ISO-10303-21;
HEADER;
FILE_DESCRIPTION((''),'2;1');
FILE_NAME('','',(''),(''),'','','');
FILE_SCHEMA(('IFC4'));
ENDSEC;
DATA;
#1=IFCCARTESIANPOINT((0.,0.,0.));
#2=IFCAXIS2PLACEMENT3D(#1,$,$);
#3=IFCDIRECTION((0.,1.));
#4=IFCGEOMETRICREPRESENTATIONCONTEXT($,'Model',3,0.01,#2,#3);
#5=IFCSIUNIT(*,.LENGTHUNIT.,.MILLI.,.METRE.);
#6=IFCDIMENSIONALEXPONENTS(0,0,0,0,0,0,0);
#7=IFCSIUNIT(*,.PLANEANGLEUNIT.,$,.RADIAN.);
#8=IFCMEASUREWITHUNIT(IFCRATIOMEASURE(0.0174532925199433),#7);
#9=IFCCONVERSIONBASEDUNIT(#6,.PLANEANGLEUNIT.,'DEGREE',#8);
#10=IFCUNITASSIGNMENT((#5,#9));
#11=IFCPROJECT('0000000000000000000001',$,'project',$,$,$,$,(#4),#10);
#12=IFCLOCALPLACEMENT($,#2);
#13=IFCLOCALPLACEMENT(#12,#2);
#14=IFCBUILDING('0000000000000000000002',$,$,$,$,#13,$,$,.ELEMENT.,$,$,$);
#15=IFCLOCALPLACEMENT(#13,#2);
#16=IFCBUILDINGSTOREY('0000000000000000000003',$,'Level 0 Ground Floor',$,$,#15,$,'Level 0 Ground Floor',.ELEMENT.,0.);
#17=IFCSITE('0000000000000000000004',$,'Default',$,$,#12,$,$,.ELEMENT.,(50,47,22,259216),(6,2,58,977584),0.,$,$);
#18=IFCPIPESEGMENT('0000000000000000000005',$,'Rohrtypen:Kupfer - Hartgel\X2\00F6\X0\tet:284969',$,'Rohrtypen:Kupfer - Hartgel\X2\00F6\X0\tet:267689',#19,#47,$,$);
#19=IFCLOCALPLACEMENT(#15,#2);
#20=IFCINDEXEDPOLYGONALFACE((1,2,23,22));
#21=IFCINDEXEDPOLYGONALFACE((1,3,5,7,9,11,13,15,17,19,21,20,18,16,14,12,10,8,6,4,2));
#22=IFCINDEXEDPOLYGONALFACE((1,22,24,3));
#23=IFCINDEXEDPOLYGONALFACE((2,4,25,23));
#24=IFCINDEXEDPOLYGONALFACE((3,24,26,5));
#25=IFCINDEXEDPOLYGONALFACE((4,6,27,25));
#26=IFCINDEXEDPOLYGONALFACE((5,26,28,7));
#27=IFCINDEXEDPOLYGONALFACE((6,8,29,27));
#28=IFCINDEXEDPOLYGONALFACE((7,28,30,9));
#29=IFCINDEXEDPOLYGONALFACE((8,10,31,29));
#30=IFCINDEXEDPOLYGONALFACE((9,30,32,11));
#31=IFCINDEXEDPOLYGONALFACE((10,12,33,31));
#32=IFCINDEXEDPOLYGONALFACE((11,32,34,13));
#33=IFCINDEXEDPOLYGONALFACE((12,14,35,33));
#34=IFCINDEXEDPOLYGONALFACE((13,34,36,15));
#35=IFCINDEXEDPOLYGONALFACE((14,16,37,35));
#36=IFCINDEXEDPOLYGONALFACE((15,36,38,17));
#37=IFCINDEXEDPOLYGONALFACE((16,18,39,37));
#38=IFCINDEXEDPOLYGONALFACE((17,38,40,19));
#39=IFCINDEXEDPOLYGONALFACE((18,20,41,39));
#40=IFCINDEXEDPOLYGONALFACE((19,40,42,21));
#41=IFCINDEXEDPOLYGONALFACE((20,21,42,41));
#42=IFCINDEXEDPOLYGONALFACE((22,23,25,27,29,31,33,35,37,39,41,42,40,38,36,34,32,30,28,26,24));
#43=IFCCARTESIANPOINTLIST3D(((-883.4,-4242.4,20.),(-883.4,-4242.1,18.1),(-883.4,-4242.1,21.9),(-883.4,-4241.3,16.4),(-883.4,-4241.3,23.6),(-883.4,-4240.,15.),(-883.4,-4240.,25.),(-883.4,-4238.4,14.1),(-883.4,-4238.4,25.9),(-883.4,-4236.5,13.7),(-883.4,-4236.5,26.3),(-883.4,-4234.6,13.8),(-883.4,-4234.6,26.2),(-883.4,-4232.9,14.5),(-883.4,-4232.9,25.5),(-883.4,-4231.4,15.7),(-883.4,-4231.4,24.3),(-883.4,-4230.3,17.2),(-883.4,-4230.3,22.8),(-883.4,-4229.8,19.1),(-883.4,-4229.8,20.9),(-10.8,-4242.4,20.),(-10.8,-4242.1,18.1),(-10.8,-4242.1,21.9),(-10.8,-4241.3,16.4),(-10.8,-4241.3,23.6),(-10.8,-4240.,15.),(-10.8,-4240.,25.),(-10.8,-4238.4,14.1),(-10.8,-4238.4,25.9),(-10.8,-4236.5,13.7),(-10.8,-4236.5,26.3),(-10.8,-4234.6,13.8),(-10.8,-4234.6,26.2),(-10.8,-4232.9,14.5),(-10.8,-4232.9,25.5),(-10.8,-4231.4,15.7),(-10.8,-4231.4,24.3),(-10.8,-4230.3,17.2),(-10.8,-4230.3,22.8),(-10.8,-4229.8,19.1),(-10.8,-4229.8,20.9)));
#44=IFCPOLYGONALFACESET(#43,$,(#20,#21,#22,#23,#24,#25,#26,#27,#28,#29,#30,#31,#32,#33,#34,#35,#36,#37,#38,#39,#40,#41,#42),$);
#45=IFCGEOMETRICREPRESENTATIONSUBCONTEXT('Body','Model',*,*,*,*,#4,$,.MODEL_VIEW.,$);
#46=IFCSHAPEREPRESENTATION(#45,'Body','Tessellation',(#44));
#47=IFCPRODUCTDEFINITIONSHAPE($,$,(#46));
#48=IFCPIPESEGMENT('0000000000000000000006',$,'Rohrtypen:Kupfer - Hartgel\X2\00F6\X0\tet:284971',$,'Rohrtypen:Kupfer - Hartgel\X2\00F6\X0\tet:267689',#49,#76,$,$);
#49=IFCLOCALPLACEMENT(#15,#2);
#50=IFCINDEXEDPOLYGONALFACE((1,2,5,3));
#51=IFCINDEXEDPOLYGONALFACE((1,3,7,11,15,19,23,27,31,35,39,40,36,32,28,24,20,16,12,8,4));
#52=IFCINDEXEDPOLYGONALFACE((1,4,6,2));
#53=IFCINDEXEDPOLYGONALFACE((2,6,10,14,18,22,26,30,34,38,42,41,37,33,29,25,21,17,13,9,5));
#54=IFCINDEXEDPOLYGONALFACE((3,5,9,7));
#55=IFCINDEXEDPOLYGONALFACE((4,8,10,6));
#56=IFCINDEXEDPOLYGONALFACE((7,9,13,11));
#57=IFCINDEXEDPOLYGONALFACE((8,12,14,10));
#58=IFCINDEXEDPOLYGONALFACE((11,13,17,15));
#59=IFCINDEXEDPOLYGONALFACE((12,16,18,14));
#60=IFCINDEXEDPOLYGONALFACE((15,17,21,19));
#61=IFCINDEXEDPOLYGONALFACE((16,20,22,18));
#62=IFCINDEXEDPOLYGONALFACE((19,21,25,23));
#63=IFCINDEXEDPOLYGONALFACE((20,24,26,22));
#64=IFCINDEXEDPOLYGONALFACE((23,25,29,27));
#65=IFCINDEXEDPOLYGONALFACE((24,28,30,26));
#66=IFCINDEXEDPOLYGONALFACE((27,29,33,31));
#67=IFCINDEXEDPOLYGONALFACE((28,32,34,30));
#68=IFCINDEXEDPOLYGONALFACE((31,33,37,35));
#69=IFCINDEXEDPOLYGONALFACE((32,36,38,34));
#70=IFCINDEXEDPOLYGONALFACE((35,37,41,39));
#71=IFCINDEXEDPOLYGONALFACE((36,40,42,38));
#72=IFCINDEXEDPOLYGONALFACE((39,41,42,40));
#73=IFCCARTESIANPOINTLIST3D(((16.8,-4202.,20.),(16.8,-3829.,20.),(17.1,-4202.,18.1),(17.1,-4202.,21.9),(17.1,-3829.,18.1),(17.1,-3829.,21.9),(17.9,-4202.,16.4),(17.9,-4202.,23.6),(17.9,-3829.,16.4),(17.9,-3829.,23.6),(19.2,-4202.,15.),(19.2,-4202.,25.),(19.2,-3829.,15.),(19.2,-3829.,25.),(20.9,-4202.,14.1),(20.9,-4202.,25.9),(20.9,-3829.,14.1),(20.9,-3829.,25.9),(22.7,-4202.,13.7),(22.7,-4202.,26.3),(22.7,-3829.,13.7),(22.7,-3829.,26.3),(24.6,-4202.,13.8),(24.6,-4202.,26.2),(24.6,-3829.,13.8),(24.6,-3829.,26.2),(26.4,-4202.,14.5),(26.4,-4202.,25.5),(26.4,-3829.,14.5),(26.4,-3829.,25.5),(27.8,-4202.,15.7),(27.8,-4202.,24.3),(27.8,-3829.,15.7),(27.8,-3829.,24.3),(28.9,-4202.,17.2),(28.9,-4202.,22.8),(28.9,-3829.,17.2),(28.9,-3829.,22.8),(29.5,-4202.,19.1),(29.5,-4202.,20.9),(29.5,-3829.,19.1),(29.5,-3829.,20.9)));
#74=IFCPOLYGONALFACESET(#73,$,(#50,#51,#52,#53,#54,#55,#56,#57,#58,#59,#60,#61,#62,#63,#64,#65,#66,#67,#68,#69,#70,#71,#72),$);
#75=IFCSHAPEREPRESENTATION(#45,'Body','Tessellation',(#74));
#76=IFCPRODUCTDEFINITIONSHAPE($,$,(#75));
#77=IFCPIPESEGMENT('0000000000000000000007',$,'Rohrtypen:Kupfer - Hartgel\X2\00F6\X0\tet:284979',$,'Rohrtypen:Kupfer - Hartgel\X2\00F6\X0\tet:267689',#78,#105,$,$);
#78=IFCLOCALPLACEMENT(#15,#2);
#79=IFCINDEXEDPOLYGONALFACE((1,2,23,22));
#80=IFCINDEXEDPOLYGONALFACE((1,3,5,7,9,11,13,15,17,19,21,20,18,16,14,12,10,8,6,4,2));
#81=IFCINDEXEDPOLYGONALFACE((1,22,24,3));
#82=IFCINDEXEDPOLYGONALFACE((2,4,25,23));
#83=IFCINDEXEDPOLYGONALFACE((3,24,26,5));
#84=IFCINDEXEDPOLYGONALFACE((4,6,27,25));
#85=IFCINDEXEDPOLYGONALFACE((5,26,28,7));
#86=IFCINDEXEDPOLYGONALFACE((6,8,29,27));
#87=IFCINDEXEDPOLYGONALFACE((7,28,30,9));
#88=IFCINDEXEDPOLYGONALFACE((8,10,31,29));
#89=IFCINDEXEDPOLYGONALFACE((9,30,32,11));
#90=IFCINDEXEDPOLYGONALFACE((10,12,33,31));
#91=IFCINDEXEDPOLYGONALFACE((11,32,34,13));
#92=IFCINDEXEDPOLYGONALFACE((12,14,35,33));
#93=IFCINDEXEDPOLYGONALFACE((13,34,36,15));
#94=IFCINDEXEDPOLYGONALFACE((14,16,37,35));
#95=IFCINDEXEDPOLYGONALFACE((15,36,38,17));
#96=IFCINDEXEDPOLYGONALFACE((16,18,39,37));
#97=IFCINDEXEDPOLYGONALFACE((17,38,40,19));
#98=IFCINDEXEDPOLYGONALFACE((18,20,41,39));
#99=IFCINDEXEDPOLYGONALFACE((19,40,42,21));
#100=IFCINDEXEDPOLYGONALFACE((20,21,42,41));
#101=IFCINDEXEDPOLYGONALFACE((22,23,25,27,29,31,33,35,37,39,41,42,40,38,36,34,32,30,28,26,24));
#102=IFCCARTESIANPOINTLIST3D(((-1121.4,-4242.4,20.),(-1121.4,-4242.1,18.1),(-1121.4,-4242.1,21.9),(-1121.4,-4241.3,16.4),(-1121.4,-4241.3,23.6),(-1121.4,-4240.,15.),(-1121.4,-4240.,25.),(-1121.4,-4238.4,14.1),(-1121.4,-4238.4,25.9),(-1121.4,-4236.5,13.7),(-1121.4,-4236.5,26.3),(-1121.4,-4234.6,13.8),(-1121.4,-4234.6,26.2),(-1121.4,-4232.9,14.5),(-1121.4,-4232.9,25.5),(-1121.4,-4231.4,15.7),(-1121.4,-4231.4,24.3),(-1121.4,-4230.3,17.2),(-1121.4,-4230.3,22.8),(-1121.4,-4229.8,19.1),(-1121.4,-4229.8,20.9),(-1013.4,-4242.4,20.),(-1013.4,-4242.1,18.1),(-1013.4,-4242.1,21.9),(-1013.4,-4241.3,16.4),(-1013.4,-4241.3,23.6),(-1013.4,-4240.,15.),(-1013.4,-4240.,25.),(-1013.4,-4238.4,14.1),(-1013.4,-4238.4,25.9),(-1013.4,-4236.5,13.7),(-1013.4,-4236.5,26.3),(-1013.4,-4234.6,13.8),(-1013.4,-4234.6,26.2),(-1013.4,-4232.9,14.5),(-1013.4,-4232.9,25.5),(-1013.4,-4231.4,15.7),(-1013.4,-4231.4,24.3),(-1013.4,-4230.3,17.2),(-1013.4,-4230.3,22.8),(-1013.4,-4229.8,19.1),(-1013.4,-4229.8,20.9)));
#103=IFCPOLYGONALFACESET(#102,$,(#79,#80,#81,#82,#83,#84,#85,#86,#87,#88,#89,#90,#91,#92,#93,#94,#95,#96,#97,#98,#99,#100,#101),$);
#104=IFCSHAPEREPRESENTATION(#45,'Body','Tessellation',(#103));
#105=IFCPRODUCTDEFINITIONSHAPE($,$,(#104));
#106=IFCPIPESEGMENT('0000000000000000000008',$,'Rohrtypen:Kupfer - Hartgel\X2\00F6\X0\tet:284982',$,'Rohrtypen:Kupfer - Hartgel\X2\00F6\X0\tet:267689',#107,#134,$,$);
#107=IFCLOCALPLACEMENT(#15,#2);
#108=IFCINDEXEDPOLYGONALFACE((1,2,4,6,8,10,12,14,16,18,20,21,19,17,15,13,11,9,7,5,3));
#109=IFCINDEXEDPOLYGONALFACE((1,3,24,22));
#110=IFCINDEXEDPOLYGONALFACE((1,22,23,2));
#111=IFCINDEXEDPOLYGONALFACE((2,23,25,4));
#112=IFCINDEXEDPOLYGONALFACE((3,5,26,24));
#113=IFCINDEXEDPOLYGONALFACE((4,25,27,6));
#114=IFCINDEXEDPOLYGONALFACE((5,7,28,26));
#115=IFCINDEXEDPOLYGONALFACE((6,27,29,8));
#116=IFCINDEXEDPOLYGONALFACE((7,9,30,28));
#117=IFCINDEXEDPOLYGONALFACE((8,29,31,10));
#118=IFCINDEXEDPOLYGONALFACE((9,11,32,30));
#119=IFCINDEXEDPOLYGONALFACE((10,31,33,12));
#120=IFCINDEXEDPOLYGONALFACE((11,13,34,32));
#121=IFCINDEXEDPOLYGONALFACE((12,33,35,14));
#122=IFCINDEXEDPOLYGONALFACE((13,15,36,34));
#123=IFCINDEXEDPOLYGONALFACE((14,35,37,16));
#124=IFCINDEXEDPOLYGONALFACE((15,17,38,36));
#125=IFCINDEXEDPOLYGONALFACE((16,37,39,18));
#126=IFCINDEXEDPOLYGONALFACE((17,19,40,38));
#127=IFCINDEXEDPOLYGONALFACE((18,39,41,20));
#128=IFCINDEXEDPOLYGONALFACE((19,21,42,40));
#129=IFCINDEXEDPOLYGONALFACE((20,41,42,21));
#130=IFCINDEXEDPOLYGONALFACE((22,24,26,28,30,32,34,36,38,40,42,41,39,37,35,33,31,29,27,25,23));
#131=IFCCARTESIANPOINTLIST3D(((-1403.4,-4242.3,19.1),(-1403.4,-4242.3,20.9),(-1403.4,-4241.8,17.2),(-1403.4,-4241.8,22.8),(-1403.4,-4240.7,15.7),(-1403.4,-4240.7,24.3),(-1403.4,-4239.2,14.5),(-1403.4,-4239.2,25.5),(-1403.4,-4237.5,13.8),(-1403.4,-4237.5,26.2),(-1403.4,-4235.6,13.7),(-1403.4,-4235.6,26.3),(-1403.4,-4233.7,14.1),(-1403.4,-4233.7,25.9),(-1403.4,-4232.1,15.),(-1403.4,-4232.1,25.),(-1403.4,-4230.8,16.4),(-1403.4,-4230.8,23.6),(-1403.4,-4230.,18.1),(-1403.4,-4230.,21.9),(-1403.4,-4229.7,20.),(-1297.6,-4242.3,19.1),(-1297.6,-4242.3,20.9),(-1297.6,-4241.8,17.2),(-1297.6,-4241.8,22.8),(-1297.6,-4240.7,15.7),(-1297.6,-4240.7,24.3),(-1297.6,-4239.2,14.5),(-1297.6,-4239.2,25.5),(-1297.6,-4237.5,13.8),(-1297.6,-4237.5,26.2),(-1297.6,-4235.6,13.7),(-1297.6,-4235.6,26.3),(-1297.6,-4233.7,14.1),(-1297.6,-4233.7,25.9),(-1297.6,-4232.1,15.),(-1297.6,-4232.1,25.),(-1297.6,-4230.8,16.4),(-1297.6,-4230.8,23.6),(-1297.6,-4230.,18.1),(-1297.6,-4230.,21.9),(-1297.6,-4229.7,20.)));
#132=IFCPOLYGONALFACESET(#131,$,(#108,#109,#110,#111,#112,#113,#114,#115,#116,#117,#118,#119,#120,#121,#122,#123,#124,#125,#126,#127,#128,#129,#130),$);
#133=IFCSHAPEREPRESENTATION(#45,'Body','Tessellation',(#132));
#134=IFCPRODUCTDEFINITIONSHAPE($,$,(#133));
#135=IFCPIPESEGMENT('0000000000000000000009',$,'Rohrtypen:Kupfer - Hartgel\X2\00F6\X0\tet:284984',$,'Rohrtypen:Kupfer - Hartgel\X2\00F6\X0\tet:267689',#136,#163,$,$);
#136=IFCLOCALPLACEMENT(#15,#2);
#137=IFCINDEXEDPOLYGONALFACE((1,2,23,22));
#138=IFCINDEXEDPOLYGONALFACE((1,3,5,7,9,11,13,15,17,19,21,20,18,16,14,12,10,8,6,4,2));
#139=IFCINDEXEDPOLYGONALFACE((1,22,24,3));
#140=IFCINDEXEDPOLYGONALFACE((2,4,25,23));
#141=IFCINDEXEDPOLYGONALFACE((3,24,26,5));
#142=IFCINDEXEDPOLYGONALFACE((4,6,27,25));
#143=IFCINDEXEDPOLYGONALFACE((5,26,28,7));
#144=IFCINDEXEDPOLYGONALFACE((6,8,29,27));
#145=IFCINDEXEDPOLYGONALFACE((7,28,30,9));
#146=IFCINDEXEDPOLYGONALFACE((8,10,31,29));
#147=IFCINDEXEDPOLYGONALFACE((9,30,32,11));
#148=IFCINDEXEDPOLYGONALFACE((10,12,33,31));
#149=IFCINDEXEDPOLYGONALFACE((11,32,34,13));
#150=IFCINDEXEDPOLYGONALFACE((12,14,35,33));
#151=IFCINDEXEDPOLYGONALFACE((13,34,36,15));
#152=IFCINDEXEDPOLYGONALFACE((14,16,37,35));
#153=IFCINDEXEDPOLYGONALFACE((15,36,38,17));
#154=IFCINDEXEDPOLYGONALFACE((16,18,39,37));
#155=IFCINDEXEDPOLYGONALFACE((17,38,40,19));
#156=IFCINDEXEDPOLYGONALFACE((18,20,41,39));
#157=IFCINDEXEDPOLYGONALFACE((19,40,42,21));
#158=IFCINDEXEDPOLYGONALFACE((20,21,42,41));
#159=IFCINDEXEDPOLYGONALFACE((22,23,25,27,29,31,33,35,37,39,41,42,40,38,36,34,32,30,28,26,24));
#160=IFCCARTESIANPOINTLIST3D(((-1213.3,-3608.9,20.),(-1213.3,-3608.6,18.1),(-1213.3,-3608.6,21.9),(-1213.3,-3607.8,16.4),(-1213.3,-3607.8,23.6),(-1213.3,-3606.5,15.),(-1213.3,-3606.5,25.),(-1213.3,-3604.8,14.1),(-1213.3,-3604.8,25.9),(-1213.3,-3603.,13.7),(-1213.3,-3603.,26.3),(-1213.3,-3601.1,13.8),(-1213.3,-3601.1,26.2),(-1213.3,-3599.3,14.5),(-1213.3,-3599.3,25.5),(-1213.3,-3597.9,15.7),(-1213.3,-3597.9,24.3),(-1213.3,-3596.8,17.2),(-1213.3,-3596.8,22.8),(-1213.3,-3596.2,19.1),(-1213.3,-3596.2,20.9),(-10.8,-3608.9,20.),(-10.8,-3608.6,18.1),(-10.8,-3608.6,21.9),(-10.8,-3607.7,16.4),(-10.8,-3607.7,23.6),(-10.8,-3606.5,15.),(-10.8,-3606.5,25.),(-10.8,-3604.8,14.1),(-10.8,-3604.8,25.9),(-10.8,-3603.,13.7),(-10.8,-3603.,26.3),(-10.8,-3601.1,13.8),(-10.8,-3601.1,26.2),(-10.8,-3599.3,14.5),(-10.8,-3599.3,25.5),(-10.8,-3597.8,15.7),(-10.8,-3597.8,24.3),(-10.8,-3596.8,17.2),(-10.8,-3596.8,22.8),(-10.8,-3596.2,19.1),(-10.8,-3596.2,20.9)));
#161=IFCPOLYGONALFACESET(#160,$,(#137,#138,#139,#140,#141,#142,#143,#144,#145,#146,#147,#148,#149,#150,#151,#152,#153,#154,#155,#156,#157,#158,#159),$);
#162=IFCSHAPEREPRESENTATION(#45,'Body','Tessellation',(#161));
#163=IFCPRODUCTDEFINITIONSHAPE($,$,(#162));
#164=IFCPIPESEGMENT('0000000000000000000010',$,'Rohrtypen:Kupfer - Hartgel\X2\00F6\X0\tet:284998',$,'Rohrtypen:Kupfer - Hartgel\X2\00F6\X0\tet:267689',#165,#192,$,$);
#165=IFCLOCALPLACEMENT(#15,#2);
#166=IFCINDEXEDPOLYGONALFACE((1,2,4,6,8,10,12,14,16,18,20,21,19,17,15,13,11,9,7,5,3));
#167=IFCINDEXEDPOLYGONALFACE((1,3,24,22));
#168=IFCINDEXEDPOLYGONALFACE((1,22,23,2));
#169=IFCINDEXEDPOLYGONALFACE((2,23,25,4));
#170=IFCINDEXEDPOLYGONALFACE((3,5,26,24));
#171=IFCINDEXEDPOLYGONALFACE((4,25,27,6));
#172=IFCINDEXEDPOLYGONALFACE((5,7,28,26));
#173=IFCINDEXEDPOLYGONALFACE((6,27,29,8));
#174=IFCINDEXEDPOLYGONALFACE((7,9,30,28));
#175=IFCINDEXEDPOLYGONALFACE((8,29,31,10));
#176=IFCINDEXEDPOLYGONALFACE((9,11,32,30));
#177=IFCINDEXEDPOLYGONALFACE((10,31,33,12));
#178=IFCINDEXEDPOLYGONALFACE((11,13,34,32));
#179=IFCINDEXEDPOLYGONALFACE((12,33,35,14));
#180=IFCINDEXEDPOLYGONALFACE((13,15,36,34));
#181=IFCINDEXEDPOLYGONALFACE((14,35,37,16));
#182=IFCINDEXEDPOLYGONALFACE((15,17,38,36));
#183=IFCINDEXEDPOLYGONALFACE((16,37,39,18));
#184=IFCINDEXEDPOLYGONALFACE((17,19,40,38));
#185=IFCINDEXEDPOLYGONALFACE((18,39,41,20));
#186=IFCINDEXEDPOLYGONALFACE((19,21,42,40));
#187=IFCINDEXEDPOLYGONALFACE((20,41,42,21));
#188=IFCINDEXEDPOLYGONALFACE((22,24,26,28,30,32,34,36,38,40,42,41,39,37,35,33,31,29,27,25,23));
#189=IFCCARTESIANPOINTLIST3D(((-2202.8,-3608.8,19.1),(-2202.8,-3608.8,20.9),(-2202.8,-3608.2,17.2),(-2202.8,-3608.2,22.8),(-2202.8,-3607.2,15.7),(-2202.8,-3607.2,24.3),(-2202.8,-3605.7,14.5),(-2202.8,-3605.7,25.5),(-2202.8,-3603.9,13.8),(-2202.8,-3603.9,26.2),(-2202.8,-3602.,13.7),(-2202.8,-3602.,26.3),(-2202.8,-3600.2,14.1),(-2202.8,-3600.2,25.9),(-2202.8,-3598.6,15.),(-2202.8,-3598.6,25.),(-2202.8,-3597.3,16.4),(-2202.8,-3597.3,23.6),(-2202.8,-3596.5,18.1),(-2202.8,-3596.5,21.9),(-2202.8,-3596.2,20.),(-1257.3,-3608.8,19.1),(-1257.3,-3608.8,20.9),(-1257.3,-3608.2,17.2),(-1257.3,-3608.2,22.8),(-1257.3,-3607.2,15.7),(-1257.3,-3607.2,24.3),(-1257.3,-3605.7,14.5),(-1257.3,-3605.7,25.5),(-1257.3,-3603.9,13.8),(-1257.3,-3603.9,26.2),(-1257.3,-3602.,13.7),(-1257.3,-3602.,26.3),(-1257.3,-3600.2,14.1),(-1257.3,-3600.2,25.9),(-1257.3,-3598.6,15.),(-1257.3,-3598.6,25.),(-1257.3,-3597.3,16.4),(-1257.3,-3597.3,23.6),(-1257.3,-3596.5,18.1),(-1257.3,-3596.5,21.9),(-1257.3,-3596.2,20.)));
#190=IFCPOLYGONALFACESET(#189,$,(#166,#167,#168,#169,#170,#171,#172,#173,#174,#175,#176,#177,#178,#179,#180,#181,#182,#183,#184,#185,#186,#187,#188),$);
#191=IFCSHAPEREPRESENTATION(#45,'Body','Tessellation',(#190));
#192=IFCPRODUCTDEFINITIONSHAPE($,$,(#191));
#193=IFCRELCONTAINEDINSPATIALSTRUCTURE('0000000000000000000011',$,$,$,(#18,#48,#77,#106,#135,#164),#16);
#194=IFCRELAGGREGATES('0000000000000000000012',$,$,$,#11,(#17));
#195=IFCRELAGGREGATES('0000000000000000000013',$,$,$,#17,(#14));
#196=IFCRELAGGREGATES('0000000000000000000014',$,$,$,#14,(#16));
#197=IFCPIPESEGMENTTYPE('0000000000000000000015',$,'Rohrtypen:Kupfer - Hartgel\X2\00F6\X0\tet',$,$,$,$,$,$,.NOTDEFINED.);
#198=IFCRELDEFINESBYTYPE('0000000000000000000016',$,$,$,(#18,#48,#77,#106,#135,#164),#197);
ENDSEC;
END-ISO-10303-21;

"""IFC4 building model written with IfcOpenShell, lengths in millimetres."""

from ifc_helpers import new_model, entity, si_unit, converted_unit, direction, frame, frame_2d, origin, place, context, subcontext, project, spatial, circle, extrude, type_object, element, save


model = new_model("IFC4")

# Units and contexts
model_context = context("Model", 3, precision=0.01, world=origin(), true_north=direction((0.0, 1.0)))
body_context = subcontext(model_context, "Body", "Model", "MODEL_VIEW")
ifc_project = project(units=[si_unit("LENGTHUNIT", "METRE", prefix="MILLI"), converted_unit("PLANEANGLEUNIT", "DEGREE", entity("IfcRatioMeasure", 0.0174532925199433), si_unit("PLANEANGLEUNIT", "RADIAN"), dimensions=[0, 0, 0, 0, 0, 0, 0])], contexts=[model_context])

# Site, building, storey
site_placement = place(None, origin())
site = spatial("IfcSite", under=ifc_project, at=site_placement, Name="Default", CompositionType="ELEMENT", RefLatitude=(50, 47, 22, 259216), RefLongitude=(6, 2, 58, 977584), RefElevation=0.0)
building_placement = place(site_placement, origin())
building = spatial("IfcBuilding", under=site, at=building_placement, CompositionType="ELEMENT")
storey_placement = place(building_placement, origin())
storey = spatial("IfcBuildingStorey", under=building, at=storey_placement, Name="Level 0 Ground Floor", LongName="Level 0 Ground Floor", CompositionType="ELEMENT", Elevation=0.0)

# Pipe segments
pipe_segment_type = type_object("IfcPipeSegmentType", Name="Rohrtypen:Kupfer - Hartgelötet", PredefinedType="NOTDEFINED")
pipe_segment_1_placement = place(storey_placement, frame((-883.4, -4244.0, 12.1)))
element("IfcPipeSegment", 1, at=pipe_segment_1_placement, inside=storey, type_object=pipe_segment_type, Name="Rohrtypen:Kupfer - Hartgelötet:284969", ObjectType="Rohrtypen:Kupfer - Hartgelötet:267689", context=body_context, shape_type="SweptSolid", body=[
    extrude(circle(Radius=6.3, at=frame_2d((0.0, 0.0), x_axis=(1.0, 0.0))), frame((0.0, 7.9, 7.9), z_axis=(1.0, 0.0, 0.0), x_axis=(0.0, -1.0, 0.0)), (0.0, 0.0, 1.0), 872.6),
])
pipe_segment_2_placement = place(storey_placement, frame((15.2, -4202.0, 12.1)))
element("IfcPipeSegment", 2, at=pipe_segment_2_placement, inside=storey, type_object=pipe_segment_type, Name="Rohrtypen:Kupfer - Hartgelötet:284971", ObjectType="Rohrtypen:Kupfer - Hartgelötet:267689", context=body_context, shape_type="SweptSolid", body=[
    extrude(circle(Radius=6.3, at=frame_2d((0.0, 0.0), x_axis=(1.0, 0.0))), frame((7.9, 0.0, 7.9), z_axis=(0.0, 1.0, 0.0), x_axis=(-1.0, 0.0, 0.0)), (0.0, 0.0, 1.0), 373.0),
])
pipe_segment_3_placement = place(storey_placement, frame((-1121.4, -4244.0, 12.1)))
element("IfcPipeSegment", 3, at=pipe_segment_3_placement, inside=storey, type_object=pipe_segment_type, Name="Rohrtypen:Kupfer - Hartgelötet:284979", ObjectType="Rohrtypen:Kupfer - Hartgelötet:267689", context=body_context, shape_type="SweptSolid", body=[
    extrude(circle(Radius=6.3, at=frame_2d((0.0, 0.0), x_axis=(1.0, 0.0))), frame((0.0, 7.9, 7.9), z_axis=(1.0, 0.0, 0.0), x_axis=(0.0, -1.0, 0.0)), (0.0, 0.0, 1.0), 108.0),
])
pipe_segment_4_placement = place(storey_placement, frame((-1403.4, -4244.0, 12.1)))
element("IfcPipeSegment", 4, at=pipe_segment_4_placement, inside=storey, type_object=pipe_segment_type, Name="Rohrtypen:Kupfer - Hartgelötet:284982", ObjectType="Rohrtypen:Kupfer - Hartgelötet:267689", context=body_context, shape_type="SweptSolid", body=[
    extrude(circle(Radius=6.3, at=frame_2d((0.0, 0.0), x_axis=(1.0, 0.0))), frame((0.0, 7.9, 7.9), z_axis=(1.0, 0.0, 0.0), x_axis=(0.0, 1.0, 0.0)), (0.0, 0.0, 1.0), 105.8),
])
pipe_segment_5_placement = place(storey_placement, frame((-1213.3, -3610.5, 12.1)))
element("IfcPipeSegment", 5, at=pipe_segment_5_placement, inside=storey, type_object=pipe_segment_type, Name="Rohrtypen:Kupfer - Hartgelötet:284984", ObjectType="Rohrtypen:Kupfer - Hartgelötet:267689", context=body_context, shape_type="SweptSolid", body=[
    extrude(circle(Radius=6.3, at=frame_2d((0.0, 0.0), x_axis=(1.0, 0.0))), frame((0.0, 7.9, 7.9), z_axis=(1.0, 0.000017, 0.0), x_axis=(0.000017, -1.0, 0.0)), (0.0, 0.0, 1.0), 1202.5),
])
pipe_segment_6_placement = place(storey_placement, frame((-2202.8, -3610.5, 12.1)))
element("IfcPipeSegment", 6, at=pipe_segment_6_placement, inside=storey, type_object=pipe_segment_type, Name="Rohrtypen:Kupfer - Hartgelötet:284998", ObjectType="Rohrtypen:Kupfer - Hartgelötet:267689", context=body_context, shape_type="SweptSolid", body=[
    extrude(circle(Radius=6.3, at=frame_2d((0.0, 0.0), x_axis=(1.0, 0.0))), frame((0.0, 7.9, 7.9), z_axis=(1.0, 0.0, 0.0), x_axis=(0.0, 1.0, 0.0)), (0.0, 0.0, 1.0), 945.5),
])

save(model, "model.ifc")
